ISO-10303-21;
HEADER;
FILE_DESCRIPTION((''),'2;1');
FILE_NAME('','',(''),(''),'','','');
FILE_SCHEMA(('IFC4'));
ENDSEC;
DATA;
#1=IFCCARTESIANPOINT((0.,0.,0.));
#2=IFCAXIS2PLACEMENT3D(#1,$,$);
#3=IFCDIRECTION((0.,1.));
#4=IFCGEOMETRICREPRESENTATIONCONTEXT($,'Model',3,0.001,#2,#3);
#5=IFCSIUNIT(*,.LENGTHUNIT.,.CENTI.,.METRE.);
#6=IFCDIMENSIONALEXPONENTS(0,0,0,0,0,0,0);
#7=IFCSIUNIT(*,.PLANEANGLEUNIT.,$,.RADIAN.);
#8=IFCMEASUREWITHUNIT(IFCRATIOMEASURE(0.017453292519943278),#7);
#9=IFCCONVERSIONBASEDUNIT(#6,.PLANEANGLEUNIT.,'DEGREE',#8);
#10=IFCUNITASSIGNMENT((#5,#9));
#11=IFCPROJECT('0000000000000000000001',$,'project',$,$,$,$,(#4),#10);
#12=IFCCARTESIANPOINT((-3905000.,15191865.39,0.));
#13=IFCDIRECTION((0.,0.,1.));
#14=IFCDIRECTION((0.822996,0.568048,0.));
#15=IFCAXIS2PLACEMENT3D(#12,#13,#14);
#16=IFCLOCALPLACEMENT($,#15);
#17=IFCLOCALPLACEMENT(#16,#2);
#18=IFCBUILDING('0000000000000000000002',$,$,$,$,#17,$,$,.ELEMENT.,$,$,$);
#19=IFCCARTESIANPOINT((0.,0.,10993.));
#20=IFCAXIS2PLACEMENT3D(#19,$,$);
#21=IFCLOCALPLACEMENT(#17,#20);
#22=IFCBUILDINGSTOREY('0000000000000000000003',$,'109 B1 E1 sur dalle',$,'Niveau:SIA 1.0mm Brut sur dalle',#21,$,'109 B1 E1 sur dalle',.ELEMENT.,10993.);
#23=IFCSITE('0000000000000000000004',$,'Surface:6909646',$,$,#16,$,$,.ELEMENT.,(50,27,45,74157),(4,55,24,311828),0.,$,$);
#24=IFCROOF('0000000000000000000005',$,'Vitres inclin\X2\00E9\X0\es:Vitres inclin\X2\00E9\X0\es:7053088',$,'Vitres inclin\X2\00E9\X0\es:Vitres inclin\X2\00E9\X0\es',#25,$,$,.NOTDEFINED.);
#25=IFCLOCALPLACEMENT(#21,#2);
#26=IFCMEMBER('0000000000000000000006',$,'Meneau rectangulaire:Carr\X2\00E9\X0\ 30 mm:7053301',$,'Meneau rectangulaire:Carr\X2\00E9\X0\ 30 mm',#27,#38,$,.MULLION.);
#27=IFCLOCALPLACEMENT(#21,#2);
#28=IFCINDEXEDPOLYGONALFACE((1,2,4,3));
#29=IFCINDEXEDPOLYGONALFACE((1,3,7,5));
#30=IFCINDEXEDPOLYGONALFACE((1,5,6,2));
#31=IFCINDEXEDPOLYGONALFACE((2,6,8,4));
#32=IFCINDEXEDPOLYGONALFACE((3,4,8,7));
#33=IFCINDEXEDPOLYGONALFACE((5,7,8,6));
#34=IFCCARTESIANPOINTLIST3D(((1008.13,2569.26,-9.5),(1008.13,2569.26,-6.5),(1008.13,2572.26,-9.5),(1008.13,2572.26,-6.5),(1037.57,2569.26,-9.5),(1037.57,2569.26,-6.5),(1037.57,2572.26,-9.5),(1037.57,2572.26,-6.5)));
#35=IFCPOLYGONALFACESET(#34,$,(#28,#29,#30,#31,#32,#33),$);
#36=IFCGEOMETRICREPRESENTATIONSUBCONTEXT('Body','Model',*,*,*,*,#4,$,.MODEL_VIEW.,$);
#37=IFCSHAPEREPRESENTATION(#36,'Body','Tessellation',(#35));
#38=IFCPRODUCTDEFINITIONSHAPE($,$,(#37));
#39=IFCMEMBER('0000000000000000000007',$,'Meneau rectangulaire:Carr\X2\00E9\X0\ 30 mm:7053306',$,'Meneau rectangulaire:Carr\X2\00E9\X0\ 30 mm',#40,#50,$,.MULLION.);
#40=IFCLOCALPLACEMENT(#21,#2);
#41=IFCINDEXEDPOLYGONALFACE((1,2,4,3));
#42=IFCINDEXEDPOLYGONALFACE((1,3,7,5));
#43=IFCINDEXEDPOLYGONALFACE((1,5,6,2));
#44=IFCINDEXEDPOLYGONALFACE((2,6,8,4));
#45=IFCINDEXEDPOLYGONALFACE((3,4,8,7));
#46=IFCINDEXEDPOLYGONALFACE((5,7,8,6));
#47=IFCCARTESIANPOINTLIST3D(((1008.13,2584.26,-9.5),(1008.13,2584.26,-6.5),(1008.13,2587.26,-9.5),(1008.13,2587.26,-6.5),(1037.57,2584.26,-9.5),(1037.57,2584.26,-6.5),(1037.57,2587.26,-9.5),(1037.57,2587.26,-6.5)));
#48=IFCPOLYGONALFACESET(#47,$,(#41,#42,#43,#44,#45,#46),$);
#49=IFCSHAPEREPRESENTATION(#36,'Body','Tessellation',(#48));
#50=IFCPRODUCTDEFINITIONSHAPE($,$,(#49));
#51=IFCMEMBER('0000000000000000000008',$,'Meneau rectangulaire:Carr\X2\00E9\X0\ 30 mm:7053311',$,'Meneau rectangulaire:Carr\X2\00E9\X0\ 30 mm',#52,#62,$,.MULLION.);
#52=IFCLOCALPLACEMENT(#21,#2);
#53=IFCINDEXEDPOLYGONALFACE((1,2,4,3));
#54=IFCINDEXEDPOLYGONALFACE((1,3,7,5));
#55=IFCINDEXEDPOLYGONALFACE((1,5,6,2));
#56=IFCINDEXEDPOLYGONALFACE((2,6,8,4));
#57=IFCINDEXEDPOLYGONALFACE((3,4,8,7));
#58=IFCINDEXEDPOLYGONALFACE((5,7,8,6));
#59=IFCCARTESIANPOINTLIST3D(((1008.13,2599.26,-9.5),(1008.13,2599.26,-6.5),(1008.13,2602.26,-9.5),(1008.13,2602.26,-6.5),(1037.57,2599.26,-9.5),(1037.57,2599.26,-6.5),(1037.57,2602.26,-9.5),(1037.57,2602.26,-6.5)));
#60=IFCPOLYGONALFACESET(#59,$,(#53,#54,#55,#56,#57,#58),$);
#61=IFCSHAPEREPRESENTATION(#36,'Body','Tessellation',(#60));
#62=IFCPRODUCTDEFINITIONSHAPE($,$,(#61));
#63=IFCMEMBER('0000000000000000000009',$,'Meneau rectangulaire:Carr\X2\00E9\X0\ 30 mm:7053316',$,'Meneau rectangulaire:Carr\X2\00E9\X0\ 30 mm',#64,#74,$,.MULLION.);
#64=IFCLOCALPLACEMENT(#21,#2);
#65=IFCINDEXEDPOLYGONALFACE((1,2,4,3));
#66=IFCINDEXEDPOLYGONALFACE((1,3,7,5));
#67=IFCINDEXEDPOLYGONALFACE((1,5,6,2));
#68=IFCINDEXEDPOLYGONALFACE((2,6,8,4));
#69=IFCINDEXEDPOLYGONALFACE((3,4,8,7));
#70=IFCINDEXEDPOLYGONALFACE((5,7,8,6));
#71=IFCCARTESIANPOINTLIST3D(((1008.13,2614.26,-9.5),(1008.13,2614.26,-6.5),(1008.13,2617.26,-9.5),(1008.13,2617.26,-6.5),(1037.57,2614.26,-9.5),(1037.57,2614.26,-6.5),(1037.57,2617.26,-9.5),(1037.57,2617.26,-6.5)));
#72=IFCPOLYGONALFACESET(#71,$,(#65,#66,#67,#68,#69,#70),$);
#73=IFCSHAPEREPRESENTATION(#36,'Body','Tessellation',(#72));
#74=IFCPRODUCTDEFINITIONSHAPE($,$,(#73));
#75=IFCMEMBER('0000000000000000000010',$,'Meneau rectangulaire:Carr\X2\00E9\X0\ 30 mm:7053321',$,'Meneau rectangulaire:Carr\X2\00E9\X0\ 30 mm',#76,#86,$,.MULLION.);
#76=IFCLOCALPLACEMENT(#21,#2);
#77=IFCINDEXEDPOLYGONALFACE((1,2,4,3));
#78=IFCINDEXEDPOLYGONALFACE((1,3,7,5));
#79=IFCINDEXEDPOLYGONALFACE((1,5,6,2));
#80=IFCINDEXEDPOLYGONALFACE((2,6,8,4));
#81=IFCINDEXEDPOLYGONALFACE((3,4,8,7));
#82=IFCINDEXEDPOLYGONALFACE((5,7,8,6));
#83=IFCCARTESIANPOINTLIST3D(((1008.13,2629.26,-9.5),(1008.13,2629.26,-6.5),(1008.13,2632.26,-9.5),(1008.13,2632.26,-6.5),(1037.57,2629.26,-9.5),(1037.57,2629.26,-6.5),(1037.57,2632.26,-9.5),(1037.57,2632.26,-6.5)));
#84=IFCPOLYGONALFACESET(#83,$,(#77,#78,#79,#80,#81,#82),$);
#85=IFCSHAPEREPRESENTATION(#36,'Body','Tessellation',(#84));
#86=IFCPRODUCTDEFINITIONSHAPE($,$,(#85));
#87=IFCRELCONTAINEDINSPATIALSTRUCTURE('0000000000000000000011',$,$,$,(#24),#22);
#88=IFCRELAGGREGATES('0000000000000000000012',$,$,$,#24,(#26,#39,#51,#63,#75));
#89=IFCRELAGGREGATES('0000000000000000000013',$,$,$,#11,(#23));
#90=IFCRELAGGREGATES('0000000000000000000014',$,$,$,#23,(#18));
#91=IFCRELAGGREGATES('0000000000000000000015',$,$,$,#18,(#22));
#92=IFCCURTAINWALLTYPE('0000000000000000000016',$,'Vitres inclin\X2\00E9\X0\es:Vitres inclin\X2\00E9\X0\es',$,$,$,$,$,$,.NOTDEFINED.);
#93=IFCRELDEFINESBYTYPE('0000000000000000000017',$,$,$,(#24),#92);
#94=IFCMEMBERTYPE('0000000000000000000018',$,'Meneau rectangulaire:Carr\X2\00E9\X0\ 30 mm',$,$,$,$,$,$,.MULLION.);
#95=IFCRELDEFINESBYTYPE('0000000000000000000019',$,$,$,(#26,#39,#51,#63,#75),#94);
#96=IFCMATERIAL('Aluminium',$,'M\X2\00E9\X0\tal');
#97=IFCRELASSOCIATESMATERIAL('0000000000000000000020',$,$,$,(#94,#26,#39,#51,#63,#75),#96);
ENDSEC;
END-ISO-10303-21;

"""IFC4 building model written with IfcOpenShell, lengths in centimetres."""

from ifc_helpers import new_model, entity, si_unit, converted_unit, direction, frame, origin, place, context, subcontext, project, spatial, indexed_curve, outline, extrude, source, transform, mapped, material, type_object, type_shapes, element, aggregate, save


model = new_model("IFC4")

# Units and contexts
model_context = context("Model", 3, precision=0.001, world=origin(), true_north=direction((0.0, 1.0)))
body_context = subcontext(model_context, "Body", "Model", "MODEL_VIEW")
ifc_project = project(units=[si_unit("LENGTHUNIT", "METRE", prefix="CENTI"), converted_unit("PLANEANGLEUNIT", "DEGREE", entity("IfcRatioMeasure", 0.017453292519943278), si_unit("PLANEANGLEUNIT", "RADIAN"), dimensions=[0, 0, 0, 0, 0, 0, 0])], contexts=[model_context])

# Site, building, storey
site_placement = place(None, frame((-3905000.0, 15191865.39, 0.0), z_axis=(0.0, 0.0, 1.0), x_axis=(0.822996, 0.568048, 0.0)))
site = spatial("IfcSite", under=ifc_project, at=site_placement, Name="Surface:6909646", CompositionType="ELEMENT", RefLatitude=(50, 27, 45, 74157), RefLongitude=(4, 55, 24, 311828), RefElevation=0.0)
building_placement = place(site_placement, origin())
building = spatial("IfcBuilding", under=site, at=building_placement, CompositionType="ELEMENT")
storey_placement = place(building_placement, frame((0.0, 0.0, 10993.0)))
storey = spatial("IfcBuildingStorey", under=building, at=storey_placement, Name="109 B1 E1 sur dalle", ObjectType="Niveau:SIA 1.0mm Brut sur dalle", LongName="109 B1 E1 sur dalle", CompositionType="ELEMENT", Elevation=10993.0)

# Roof, members
curtain_wall_type = type_object("IfcCurtainWallType", Name="Vitres inclinées:Vitres inclinées", PredefinedType="NOTDEFINED")
roof_placement = place(storey_placement, frame((0.0, 0.0, -10993.0)))
roof = element("IfcRoof", 1, at=roof_placement, inside=storey, type_object=curtain_wall_type, Name="Vitres inclinées:Vitres inclinées:7053088", ObjectType="Vitres inclinées:Vitres inclinées", PredefinedType="NOTDEFINED")
ifc_material = material(Name="Aluminium", Category="Métal")
member_type_1 = type_object("IfcMemberType", Name="Meneau rectangulaire:Carré 30 mm", PredefinedType="MULLION", material=ifc_material)
shared_shape_1 = source(origin(), body_context, "Body", "SweptSolid", [
    extrude(outline(indexed_curve([(-1.5, -1.5), (1.5, -1.5), (1.5, 1.5), (-1.5, 1.5), (-1.5, -1.5)], self_intersect=False)), frame((0.0, 0.0, -29.44), z_axis=(0.0, 0.0, 1.0), x_axis=(0.0, -1.0, 0.0)), (0.0, 0.0, 1.0), 29.44),
])
type_shapes(member_type_1, [shared_shape_1])
member_1_placement = place(roof_placement, frame((1008.13, 2570.76, 10985.0), z_axis=(-1.0, 0.0, 0.0), x_axis=(0.0, 1.0, 0.0)))
member_1 = element("IfcMember", 2, at=member_1_placement, type_object=member_type_1, material=ifc_material, Name="Meneau rectangulaire:Carré 30 mm:7053301", ObjectType="Meneau rectangulaire:Carré 30 mm", PredefinedType="MULLION", context=body_context, shape_type="MappedRepresentation", body=[
    mapped(shared_shape_1, transform((0.0, 0.0, 0.0), scale=1.0)),
])
member_2_placement = place(roof_placement, frame((1008.13, 2585.76, 10985.0), z_axis=(-1.0, 0.0, 0.0), x_axis=(0.0, 1.0, 0.0)))
member_2 = element("IfcMember", 3, at=member_2_placement, type_object=member_type_1, material=ifc_material, Name="Meneau rectangulaire:Carré 30 mm:7053306", ObjectType="Meneau rectangulaire:Carré 30 mm", PredefinedType="MULLION", context=body_context, shape_type="MappedRepresentation", body=[
    mapped(shared_shape_1, transform((0.0, 0.0, 0.0), scale=1.0)),
])
member_3_placement = place(roof_placement, frame((1008.13, 2600.76, 10985.0), z_axis=(-1.0, 0.0, 0.0), x_axis=(0.0, 1.0, 0.0)))
member_3 = element("IfcMember", 4, at=member_3_placement, type_object=member_type_1, material=ifc_material, Name="Meneau rectangulaire:Carré 30 mm:7053311", ObjectType="Meneau rectangulaire:Carré 30 mm", PredefinedType="MULLION", context=body_context, shape_type="MappedRepresentation", body=[
    mapped(shared_shape_1, transform((0.0, 0.0, 0.0), scale=1.0)),
])
member_4_placement = place(roof_placement, frame((1008.13, 2615.76, 10985.0), z_axis=(-1.0, 0.0, 0.0), x_axis=(0.0, 1.0, 0.0)))
member_4 = element("IfcMember", 5, at=member_4_placement, type_object=member_type_1, material=ifc_material, Name="Meneau rectangulaire:Carré 30 mm:7053316", ObjectType="Meneau rectangulaire:Carré 30 mm", PredefinedType="MULLION", context=body_context, shape_type="MappedRepresentation", body=[
    mapped(shared_shape_1, transform((0.0, 0.0, 0.0), scale=1.0)),
])
member_5_placement = place(roof_placement, frame((1008.13, 2630.76, 10985.0), z_axis=(-1.0, 0.0, 0.0), x_axis=(0.0, 1.0, 0.0)))
member_5 = element("IfcMember", 6, at=member_5_placement, type_object=member_type_1, material=ifc_material, Name="Meneau rectangulaire:Carré 30 mm:7053321", ObjectType="Meneau rectangulaire:Carré 30 mm", PredefinedType="MULLION", context=body_context, shape_type="MappedRepresentation", body=[
    mapped(shared_shape_1, transform((0.0, 0.0, 0.0), scale=1.0)),
])
aggregate(roof, [member_1, member_2, member_3, member_4, member_5])

save(model, "model.ifc")
